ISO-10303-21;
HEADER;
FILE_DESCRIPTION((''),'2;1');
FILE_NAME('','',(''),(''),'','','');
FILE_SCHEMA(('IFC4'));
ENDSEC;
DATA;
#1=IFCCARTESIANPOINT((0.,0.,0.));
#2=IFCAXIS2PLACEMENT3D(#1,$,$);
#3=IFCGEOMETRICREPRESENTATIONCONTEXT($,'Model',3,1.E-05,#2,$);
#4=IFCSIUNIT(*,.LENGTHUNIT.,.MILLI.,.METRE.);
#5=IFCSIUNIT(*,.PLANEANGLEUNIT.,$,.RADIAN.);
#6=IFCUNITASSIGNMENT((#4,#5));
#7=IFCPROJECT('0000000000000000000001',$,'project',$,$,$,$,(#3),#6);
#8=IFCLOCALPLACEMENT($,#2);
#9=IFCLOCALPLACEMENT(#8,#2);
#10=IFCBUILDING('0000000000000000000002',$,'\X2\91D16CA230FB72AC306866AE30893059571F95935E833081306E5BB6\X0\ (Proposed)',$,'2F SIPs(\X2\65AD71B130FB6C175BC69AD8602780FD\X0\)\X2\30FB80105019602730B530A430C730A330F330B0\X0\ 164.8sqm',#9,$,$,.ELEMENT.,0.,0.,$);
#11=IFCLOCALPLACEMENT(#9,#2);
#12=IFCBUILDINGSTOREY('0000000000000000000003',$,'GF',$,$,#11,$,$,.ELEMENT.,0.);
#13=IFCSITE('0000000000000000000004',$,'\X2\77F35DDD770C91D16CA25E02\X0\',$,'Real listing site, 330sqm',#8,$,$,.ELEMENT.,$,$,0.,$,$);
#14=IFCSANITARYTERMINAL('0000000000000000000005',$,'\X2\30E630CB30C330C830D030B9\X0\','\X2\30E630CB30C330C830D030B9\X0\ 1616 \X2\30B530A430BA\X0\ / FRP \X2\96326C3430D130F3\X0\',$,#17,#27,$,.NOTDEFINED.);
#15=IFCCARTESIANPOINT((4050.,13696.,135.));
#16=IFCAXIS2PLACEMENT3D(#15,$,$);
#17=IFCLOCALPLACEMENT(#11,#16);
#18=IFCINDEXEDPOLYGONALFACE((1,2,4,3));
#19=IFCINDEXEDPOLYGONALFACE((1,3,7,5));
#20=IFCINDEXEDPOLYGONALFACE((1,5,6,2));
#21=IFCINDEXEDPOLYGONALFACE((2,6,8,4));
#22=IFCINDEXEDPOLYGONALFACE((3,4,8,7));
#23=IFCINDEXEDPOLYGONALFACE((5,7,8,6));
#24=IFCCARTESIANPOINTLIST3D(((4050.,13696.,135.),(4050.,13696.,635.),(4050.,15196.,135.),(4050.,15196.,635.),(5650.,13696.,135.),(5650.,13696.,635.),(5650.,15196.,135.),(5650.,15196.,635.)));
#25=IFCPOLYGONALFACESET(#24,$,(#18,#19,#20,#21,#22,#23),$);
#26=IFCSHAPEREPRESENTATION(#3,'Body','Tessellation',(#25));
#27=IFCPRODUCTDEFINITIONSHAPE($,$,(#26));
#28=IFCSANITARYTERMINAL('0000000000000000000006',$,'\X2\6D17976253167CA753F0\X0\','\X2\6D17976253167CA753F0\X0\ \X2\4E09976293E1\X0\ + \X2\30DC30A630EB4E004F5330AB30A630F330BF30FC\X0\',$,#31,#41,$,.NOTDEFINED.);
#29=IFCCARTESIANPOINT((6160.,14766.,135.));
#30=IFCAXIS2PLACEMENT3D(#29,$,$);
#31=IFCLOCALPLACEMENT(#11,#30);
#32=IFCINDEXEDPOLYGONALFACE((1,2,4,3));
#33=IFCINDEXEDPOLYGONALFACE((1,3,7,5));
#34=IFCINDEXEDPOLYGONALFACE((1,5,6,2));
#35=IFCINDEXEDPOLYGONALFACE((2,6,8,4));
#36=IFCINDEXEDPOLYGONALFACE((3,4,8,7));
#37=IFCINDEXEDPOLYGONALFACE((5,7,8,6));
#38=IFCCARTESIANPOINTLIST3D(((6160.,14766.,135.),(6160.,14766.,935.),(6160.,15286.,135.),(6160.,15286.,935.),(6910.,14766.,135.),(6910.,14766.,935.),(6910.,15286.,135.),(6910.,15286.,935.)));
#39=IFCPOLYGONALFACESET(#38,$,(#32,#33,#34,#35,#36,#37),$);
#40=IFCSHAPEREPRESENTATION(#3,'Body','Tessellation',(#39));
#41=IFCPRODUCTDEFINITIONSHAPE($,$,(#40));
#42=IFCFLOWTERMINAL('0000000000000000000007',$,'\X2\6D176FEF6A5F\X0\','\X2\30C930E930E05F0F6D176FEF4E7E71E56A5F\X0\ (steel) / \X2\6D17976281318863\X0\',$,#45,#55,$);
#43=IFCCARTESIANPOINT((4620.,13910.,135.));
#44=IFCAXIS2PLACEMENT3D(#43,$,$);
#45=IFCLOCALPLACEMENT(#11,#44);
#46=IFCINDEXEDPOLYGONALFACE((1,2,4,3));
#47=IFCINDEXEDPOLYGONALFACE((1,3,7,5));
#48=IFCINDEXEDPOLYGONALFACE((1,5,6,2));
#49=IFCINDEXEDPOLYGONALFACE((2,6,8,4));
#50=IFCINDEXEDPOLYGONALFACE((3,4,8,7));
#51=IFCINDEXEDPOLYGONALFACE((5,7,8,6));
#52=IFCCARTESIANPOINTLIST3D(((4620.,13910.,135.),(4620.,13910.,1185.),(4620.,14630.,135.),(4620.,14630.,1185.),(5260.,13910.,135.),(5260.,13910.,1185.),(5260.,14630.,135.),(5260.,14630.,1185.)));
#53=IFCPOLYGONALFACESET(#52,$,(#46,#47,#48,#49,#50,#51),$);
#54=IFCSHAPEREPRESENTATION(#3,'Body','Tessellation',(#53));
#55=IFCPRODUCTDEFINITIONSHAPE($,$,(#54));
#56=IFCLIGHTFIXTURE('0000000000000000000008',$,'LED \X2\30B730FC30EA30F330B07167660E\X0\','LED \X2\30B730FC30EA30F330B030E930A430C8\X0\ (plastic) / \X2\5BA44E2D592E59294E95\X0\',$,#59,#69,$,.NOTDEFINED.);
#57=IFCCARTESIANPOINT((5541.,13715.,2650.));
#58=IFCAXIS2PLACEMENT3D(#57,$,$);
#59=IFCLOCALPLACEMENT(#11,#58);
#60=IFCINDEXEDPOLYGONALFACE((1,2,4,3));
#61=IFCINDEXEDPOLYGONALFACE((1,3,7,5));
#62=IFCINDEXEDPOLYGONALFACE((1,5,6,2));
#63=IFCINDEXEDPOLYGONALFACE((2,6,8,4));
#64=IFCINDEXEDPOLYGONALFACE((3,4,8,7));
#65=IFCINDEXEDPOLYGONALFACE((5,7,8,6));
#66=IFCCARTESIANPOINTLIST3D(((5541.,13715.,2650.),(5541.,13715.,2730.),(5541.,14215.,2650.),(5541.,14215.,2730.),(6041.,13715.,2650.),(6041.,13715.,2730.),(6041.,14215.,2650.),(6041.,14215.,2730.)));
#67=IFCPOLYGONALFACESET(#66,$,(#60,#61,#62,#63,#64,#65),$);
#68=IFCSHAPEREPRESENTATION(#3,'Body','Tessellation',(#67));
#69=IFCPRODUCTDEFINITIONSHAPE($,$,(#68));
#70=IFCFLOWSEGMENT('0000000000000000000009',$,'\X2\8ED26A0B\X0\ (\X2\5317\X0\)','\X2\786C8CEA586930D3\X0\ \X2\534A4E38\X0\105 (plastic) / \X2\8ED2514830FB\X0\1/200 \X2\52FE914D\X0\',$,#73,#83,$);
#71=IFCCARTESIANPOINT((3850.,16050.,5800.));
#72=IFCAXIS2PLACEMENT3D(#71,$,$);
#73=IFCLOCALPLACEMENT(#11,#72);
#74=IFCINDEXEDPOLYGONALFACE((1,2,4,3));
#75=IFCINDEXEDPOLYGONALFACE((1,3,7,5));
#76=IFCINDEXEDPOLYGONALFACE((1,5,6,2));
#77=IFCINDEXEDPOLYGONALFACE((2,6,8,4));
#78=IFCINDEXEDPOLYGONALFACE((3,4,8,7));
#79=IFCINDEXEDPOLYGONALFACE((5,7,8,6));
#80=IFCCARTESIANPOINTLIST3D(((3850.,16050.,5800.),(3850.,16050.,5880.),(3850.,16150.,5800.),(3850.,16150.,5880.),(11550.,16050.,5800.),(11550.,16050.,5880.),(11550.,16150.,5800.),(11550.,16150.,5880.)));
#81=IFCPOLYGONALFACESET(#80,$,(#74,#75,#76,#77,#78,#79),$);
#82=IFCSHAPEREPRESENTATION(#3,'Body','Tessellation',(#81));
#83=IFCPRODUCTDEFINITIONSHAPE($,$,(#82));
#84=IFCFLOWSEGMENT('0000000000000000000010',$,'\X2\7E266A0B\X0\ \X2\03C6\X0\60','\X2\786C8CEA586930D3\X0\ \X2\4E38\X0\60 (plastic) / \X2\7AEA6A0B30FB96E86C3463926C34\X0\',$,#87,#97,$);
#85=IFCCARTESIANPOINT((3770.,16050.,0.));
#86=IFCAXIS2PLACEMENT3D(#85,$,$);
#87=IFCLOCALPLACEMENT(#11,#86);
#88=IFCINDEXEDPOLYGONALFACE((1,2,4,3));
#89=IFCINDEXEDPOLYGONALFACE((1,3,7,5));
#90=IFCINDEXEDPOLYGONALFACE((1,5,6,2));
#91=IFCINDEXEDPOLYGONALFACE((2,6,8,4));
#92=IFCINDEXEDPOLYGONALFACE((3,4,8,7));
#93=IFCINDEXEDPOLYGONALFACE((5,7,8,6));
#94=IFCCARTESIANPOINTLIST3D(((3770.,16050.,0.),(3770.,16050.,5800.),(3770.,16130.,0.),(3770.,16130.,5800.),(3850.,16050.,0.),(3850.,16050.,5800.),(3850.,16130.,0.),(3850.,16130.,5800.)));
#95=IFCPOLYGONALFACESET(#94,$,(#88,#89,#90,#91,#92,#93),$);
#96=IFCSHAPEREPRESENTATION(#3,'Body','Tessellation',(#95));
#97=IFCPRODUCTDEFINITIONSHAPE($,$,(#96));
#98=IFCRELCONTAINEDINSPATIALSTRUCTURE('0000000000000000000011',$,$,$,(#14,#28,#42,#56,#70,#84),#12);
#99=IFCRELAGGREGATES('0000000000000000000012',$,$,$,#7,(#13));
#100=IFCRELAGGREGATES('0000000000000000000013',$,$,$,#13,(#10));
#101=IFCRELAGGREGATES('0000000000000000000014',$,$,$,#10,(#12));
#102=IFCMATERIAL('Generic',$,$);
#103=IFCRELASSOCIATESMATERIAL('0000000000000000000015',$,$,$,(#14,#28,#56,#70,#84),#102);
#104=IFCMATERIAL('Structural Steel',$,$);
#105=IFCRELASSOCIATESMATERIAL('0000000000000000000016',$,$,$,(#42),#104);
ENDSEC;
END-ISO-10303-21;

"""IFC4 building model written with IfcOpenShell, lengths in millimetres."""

from ifc_helpers import new_model, si_unit, frame, frame_2d, origin, place, context, project, spatial, rectangle, extrude, material, element, save


model = new_model("IFC4")

# Units and contexts
model_context = context("Model", 3, precision=1e-05, world=origin())
ifc_project = project(units=[si_unit("LENGTHUNIT", "METRE", prefix="MILLI"), si_unit("PLANEANGLEUNIT", "RADIAN")], contexts=[model_context])

# Site, building, storey
site_placement = place(None, origin())
site = spatial("IfcSite", under=ifc_project, at=site_placement, Name="石川県金沢市", ObjectType="Real listing site, 330sqm", CompositionType="ELEMENT", RefElevation=0.0)
building_placement = place(site_placement, origin())
building = spatial("IfcBuilding", under=site, at=building_placement, Name="金沢・犬と暮らす土間広めの家 (Proposed)", ObjectType="2F SIPs(断熱・気密高性能)・耐候性サイディング 164.8sqm", CompositionType="ELEMENT", ElevationOfRefHeight=0.0, ElevationOfTerrain=0.0)
storey_placement = place(building_placement, origin())
storey = spatial("IfcBuildingStorey", under=building, at=storey_placement, Name="GF", CompositionType="ELEMENT", Elevation=0.0)

# Sanitary terminals
ifc_material_1 = material(Name="Generic")
sanitary_terminal_1_placement = place(storey_placement, frame((4050.0, 13696.0, 135.0)))
element("IfcSanitaryTerminal", 1, at=sanitary_terminal_1_placement, inside=storey, material=ifc_material_1, Name="ユニットバス", Description="ユニットバス 1616 サイズ / FRP 防水パン", PredefinedType="NOTDEFINED", context=model_context, shape_type="SweptSolid", body=[
    extrude(rectangle(XDim=1600.0, YDim=1500.0, at=frame_2d((800.0, 750.0))), frame((4050.0, 13696.0, 135.0)), (0.0, 0.0, 1.0), 500.0),
])
sanitary_terminal_2_placement = place(storey_placement, frame((6160.0, 14766.0, 135.0)))
element("IfcSanitaryTerminal", 2, at=sanitary_terminal_2_placement, inside=storey, material=ifc_material_1, Name="洗面化粧台", Description="洗面化粧台 三面鏡 + ボウル一体カウンター", PredefinedType="NOTDEFINED", context=model_context, shape_type="SweptSolid", body=[
    extrude(rectangle(XDim=750.0, YDim=520.0, at=frame_2d((375.0, 260.0))), frame((6160.0, 14766.0, 135.0)), (0.0, 0.0, 1.0), 800.0),
])

# Flow terminal
ifc_material_2 = material(Name="Structural Steel")
flow_terminal_placement = place(storey_placement, frame((4620.0, 13910.0, 135.0)))
element("IfcFlowTerminal", 3, at=flow_terminal_placement, inside=storey, material=ifc_material_2, Name="洗濯機", Description="ドラム式洗濯乾燥機 (steel) / 洗面脱衣", context=model_context, shape_type="SweptSolid", body=[
    extrude(rectangle(XDim=640.0, YDim=720.0, at=frame_2d((320.0, 360.0))), frame((4620.0, 13910.0, 135.0)), (0.0, 0.0, 1.0), 1050.0),
])

# Light fixture
light_fixture_placement = place(storey_placement, frame((5541.0, 13715.0, 2650.0)))
element("IfcLightFixture", 4, at=light_fixture_placement, inside=storey, material=ifc_material_1, Name="LED シーリング照明", Description="LED シーリングライト (plastic) / 室中央天井", PredefinedType="NOTDEFINED", context=model_context, shape_type="SweptSolid", body=[
    extrude(rectangle(XDim=500.0, YDim=500.0, at=frame_2d((250.0, 250.0))), frame((5541.0, 13715.0, 2650.0)), (0.0, 0.0, 1.0), 80.0),
])

# Flow segments
flow_segment_1_placement = place(storey_placement, frame((3850.0, 16050.0, 5800.0)))
element("IfcFlowSegment", 5, at=flow_segment_1_placement, inside=storey, material=ifc_material_1, Name="軒樋 (北)", Description="硬質塩ビ 半丸105 (plastic) / 軒先・1/200 勾配", context=model_context, shape_type="SweptSolid", body=[
    extrude(rectangle(XDim=7700.0, YDim=100.0, at=frame_2d((3850.0, 50.0))), frame((3850.0, 16050.0, 5800.0)), (0.0, 0.0, 1.0), 80.0),
])
flow_segment_2_placement = place(storey_placement, frame((3770.0, 16050.0, 0.0)))
element("IfcFlowSegment", 6, at=flow_segment_2_placement, inside=storey, material=ifc_material_1, Name="縦樋 φ60", Description="硬質塩ビ 丸60 (plastic) / 竪樋・雨水排水", context=model_context, shape_type="SweptSolid", body=[
    extrude(rectangle(XDim=80.0, YDim=80.0, at=frame_2d((40.0, 40.0))), frame((3770.0, 16050.0, 0.0)), (0.0, 0.0, 1.0), 5800.0),
])

save(model, "model.ifc")
